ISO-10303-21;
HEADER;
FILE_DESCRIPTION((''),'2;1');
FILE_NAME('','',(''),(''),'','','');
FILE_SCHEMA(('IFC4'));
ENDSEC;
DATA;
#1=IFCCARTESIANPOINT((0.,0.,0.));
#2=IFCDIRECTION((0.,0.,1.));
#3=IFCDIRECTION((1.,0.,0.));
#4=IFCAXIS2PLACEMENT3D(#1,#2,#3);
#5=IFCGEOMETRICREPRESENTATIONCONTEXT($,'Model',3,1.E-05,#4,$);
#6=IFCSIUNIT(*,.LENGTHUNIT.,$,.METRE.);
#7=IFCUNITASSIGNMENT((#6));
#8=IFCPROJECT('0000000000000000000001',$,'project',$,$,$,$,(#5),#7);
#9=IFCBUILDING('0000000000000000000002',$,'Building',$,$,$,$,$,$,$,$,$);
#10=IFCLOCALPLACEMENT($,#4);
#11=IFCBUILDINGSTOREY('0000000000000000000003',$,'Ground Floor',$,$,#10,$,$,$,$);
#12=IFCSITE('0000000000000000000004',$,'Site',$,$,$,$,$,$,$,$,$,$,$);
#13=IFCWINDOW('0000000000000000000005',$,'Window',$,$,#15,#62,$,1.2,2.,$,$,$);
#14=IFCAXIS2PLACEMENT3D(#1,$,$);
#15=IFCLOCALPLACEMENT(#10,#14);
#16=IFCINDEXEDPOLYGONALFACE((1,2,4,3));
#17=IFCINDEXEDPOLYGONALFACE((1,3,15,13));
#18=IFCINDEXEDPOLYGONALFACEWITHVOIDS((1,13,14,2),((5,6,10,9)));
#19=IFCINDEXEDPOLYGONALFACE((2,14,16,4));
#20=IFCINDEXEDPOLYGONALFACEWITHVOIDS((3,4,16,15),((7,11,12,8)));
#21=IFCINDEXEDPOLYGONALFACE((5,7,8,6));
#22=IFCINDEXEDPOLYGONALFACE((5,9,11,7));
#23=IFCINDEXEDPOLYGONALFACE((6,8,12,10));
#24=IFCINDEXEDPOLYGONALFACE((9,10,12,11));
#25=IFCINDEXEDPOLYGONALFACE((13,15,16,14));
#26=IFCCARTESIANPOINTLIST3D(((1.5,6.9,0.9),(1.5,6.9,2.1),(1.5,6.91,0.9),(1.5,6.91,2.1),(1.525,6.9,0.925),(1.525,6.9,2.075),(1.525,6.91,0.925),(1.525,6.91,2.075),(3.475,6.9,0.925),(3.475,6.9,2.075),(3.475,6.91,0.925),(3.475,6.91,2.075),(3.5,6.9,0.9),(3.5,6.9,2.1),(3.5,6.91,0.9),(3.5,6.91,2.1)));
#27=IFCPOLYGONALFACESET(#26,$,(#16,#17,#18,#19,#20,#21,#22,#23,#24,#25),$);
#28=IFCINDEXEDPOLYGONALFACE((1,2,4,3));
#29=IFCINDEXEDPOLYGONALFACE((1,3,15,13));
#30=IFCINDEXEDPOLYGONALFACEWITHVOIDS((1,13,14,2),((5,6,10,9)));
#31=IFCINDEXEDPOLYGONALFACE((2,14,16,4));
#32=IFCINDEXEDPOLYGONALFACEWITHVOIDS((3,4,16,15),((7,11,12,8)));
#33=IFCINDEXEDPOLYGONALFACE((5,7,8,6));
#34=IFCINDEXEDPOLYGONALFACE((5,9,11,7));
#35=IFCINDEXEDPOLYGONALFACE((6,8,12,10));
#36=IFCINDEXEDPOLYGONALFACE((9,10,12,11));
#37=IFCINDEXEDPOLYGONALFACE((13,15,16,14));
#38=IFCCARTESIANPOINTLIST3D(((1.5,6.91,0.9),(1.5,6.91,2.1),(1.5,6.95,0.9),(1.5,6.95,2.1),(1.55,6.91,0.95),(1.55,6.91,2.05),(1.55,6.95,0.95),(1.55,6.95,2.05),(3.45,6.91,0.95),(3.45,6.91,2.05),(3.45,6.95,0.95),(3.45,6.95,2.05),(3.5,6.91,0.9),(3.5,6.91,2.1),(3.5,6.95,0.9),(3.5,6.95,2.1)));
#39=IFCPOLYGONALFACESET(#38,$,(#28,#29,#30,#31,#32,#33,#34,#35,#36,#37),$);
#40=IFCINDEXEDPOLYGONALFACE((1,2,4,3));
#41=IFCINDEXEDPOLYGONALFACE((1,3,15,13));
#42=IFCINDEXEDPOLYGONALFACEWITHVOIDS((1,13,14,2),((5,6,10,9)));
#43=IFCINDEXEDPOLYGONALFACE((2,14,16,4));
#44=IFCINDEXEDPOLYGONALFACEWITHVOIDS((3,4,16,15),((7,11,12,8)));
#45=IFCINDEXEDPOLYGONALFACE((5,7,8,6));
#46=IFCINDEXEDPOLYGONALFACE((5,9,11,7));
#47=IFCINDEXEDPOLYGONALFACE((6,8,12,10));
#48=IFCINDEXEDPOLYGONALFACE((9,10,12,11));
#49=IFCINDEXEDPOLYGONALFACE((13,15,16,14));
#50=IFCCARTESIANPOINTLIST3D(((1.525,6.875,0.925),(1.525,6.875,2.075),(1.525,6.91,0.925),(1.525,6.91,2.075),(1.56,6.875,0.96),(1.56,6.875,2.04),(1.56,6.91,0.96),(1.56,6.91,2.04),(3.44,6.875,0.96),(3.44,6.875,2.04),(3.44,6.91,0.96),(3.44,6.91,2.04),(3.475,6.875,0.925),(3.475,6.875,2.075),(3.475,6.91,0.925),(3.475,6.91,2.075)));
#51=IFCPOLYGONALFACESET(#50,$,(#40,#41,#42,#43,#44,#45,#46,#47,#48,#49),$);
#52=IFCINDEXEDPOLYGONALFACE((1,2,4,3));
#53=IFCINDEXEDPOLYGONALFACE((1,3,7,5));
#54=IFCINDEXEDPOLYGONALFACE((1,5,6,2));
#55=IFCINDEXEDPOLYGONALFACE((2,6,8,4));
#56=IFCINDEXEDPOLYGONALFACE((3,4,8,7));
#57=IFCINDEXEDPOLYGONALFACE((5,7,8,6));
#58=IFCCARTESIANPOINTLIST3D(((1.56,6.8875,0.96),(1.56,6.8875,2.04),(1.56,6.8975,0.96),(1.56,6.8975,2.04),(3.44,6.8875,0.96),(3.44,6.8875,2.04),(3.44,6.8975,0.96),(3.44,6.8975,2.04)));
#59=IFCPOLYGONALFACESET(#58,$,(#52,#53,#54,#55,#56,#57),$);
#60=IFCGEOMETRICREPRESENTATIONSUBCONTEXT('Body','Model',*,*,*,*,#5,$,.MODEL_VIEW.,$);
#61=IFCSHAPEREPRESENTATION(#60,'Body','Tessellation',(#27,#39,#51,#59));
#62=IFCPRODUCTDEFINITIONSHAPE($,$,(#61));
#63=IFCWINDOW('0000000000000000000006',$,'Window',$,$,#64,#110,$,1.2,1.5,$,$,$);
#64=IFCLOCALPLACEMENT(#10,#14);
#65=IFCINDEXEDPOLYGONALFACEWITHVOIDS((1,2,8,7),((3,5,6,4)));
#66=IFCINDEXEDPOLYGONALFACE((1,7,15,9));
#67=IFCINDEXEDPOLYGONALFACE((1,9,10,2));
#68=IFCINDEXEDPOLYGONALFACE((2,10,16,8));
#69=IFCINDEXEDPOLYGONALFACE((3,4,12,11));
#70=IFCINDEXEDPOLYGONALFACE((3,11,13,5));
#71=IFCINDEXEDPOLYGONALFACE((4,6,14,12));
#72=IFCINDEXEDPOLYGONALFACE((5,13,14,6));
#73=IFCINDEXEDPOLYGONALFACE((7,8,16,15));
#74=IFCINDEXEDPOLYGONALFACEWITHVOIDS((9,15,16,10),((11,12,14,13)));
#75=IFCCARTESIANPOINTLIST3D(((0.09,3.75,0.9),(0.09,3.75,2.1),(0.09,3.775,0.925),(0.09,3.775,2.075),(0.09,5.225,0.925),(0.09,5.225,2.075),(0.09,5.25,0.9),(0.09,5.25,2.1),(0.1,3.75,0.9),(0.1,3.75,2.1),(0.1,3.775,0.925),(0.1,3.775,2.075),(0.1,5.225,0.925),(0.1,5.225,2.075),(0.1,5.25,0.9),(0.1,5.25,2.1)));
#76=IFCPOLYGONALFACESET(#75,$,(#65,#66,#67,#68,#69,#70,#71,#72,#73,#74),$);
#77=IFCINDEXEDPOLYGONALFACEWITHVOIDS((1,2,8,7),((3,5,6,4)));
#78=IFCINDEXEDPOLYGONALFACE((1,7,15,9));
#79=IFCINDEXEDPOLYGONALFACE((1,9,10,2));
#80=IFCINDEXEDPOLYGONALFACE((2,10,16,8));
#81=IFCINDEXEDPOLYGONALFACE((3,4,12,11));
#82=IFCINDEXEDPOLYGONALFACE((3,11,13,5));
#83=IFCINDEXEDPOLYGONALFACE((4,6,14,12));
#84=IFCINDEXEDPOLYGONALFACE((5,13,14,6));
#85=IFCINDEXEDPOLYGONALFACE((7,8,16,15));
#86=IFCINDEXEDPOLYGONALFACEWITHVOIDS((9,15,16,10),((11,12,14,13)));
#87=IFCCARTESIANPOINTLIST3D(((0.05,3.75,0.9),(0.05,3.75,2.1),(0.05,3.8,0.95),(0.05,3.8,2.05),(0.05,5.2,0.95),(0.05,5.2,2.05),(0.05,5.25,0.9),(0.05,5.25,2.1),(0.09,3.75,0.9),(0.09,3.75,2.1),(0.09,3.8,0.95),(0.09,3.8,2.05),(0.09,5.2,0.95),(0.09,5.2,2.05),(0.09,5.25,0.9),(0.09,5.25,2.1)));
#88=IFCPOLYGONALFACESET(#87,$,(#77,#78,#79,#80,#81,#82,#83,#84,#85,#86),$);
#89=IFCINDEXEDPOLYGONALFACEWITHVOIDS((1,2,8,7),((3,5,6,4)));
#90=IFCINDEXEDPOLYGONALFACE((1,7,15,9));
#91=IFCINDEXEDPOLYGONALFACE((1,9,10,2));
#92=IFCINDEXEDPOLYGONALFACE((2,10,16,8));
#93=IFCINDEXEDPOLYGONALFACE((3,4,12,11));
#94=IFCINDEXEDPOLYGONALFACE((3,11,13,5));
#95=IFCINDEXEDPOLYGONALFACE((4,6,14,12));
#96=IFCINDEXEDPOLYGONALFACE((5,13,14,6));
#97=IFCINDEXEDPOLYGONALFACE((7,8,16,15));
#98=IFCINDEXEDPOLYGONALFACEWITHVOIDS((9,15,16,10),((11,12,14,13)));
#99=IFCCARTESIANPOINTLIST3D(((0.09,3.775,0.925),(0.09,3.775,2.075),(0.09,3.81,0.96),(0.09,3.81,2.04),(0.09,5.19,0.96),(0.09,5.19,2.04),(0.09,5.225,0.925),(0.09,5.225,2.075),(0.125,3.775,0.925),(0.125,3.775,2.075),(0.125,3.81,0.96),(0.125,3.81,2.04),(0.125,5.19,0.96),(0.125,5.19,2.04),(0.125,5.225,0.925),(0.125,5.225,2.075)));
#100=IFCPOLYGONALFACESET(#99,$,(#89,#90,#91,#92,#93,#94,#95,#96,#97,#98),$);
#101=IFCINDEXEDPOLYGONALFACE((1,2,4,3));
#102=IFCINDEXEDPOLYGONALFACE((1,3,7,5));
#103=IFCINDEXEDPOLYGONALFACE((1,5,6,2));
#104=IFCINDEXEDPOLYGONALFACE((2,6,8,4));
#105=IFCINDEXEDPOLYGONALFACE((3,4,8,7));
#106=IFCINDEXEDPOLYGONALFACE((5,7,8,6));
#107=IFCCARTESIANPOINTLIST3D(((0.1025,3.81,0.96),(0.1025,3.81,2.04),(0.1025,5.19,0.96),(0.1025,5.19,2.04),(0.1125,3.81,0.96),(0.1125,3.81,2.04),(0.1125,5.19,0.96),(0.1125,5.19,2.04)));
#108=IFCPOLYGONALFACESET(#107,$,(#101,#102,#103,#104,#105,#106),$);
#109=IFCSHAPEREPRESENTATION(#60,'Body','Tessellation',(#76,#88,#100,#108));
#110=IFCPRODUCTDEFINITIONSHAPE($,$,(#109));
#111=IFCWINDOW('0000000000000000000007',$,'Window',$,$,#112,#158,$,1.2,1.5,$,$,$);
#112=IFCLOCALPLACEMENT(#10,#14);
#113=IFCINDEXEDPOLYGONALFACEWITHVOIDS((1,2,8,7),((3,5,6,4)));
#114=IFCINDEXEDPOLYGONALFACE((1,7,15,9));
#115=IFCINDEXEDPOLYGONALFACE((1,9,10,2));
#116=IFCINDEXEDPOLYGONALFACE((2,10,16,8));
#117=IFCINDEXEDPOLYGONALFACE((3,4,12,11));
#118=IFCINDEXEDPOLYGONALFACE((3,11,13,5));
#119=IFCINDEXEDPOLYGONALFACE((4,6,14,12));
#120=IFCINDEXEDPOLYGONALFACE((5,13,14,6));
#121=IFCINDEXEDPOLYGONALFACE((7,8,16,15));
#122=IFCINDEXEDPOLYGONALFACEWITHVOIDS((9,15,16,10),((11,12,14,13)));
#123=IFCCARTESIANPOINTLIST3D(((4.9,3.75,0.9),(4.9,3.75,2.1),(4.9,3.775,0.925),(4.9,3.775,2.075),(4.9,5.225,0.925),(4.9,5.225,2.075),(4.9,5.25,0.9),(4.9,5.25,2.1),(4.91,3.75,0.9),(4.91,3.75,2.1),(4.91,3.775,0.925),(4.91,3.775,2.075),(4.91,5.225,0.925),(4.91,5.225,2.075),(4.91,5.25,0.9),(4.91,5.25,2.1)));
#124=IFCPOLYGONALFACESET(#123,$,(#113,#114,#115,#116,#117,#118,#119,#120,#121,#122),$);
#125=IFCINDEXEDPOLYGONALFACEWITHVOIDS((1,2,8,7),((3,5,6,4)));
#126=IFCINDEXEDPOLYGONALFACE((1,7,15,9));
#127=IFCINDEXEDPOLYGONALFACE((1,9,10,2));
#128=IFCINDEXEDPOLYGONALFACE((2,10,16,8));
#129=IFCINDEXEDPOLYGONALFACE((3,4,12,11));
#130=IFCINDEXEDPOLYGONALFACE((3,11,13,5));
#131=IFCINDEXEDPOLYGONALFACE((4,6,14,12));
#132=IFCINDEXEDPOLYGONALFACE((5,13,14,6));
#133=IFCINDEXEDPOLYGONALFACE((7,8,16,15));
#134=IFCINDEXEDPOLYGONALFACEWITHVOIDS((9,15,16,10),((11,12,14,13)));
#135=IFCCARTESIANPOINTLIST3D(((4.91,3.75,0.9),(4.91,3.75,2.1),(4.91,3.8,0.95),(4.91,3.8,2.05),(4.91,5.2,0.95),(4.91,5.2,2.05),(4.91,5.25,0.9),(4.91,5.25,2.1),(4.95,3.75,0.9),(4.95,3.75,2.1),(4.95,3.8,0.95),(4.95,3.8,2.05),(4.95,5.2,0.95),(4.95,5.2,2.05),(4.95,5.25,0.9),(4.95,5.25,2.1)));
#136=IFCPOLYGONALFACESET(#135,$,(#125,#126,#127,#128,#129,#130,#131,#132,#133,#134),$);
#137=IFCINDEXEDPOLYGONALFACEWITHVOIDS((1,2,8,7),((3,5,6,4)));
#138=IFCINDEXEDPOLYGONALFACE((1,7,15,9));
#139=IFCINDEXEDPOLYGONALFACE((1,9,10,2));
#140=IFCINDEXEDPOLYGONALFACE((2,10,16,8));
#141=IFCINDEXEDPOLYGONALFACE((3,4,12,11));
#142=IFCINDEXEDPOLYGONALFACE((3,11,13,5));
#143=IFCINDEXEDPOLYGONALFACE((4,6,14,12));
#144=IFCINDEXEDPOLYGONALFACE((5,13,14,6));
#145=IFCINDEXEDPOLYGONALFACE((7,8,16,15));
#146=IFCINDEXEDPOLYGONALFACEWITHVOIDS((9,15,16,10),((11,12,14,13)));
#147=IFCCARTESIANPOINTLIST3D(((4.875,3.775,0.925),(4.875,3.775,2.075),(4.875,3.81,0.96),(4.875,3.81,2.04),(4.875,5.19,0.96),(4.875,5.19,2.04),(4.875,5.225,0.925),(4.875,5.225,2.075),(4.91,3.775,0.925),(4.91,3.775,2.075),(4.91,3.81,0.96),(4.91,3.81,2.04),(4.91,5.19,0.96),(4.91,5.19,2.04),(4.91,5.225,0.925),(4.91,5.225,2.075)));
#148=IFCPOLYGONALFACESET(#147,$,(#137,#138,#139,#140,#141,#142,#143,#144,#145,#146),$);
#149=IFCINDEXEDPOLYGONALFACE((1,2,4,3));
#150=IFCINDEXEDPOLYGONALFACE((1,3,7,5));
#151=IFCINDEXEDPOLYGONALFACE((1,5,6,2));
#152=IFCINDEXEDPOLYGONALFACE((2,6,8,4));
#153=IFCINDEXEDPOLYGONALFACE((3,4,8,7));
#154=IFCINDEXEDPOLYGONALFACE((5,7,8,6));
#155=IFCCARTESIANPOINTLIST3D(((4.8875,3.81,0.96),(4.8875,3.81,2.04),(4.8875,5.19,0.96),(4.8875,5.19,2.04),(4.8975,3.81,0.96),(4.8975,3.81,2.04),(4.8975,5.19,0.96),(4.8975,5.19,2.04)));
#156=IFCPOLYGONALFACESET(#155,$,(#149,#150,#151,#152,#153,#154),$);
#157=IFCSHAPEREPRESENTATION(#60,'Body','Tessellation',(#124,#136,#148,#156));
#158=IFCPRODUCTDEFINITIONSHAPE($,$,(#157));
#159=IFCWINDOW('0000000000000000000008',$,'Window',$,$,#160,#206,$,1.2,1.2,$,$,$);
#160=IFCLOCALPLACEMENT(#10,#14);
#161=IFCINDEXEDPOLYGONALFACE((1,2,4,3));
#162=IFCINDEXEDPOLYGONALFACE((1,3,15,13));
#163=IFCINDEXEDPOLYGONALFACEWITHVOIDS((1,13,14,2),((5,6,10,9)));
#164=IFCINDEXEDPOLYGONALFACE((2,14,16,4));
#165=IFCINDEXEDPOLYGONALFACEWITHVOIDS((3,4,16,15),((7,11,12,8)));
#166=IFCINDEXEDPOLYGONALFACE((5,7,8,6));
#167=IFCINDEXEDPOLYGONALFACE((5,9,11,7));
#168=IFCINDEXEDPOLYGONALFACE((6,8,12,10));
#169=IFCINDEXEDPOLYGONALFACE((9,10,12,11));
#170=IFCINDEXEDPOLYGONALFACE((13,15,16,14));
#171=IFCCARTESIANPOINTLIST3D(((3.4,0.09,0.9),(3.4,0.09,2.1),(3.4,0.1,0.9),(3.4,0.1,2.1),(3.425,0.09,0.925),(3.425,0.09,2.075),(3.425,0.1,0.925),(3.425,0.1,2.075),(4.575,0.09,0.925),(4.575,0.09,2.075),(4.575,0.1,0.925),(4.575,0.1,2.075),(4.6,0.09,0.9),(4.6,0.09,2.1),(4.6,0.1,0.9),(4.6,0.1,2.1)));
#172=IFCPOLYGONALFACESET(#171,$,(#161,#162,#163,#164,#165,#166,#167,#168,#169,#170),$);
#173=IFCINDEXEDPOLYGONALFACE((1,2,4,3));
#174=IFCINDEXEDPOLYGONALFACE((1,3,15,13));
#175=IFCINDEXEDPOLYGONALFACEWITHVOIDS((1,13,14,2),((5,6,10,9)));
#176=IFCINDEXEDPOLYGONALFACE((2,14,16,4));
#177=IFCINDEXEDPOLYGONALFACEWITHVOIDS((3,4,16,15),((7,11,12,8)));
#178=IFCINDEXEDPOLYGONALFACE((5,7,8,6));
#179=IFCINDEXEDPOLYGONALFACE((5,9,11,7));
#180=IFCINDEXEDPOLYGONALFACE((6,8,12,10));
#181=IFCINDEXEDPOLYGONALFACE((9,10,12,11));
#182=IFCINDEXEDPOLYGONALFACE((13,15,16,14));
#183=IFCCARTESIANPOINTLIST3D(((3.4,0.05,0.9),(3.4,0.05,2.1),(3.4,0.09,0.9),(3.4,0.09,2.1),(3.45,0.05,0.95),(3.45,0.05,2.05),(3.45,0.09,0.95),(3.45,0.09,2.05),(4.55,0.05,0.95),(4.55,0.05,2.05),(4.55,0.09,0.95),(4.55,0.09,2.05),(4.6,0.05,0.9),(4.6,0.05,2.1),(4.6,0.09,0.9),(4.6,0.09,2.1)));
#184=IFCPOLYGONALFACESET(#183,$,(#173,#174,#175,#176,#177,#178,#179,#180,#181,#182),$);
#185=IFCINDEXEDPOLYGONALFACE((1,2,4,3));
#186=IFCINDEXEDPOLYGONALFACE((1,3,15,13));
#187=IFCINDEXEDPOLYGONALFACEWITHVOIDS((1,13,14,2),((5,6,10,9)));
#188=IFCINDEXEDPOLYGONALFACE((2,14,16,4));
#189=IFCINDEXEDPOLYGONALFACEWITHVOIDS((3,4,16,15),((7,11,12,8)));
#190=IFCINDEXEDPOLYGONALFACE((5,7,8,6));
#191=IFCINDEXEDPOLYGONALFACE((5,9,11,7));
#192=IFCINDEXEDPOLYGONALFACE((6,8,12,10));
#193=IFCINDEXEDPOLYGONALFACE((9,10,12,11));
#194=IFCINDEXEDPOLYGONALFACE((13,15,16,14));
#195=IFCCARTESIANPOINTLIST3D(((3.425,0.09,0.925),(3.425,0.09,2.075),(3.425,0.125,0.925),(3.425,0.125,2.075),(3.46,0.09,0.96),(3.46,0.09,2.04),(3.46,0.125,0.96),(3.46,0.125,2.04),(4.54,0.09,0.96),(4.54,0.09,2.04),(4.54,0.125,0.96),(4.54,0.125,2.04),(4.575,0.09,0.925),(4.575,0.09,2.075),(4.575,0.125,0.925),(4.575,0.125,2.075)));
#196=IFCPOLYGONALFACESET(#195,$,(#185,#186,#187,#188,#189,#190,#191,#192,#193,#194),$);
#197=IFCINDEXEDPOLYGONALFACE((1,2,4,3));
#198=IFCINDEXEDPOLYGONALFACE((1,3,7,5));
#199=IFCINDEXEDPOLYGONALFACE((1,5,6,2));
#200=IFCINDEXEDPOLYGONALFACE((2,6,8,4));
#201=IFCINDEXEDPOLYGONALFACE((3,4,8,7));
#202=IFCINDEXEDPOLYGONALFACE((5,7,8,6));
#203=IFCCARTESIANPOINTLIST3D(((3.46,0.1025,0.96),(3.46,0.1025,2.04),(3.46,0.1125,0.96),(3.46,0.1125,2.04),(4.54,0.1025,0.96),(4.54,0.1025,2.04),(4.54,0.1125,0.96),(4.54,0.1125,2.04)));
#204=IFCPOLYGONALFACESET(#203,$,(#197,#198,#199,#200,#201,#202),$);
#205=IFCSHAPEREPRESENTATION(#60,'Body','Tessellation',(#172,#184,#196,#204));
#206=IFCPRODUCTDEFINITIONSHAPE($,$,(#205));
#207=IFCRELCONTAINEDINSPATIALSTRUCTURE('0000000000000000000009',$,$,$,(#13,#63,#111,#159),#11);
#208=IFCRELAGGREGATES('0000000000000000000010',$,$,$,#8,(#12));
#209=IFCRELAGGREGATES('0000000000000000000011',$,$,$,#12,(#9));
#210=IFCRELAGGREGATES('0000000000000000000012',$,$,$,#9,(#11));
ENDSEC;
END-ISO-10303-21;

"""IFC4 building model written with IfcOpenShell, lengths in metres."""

from ifc_helpers import new_model, si_unit, frame, origin_with_axes, place, context, subcontext, project, spatial, line, indexed_curve, outline, extrude, element, save


model = new_model("IFC4")

# Units and contexts
model_context = context("Model", 3, precision=1e-05, world=origin_with_axes())
body_context = subcontext(model_context, "Body", "Model", "MODEL_VIEW")
ifc_project = project(units=[si_unit("LENGTHUNIT", "METRE")], contexts=[model_context])

# Site, building, storey
site = spatial("IfcSite", under=ifc_project, Name="Site")
building = spatial("IfcBuilding", under=site, Name="Building")
storey_placement = place(None, origin_with_axes())
storey = spatial("IfcBuildingStorey", under=building, at=storey_placement, Name="Ground Floor")

# Windows
window_1_placement = place(storey_placement, frame((3.5, 7.0, 0.9), z_axis=(0.0, 0.0, 1.0), x_axis=(-1.0, 0.0, 0.0)))
element("IfcWindow", 1, at=window_1_placement, inside=storey, Name="Window", OverallHeight=1.2, OverallWidth=2.0, context=body_context, shape_type="SweptSolid", body=[
    extrude(outline(indexed_curve([(0.0, 0.0), (2.0, 0.0), (2.0, 1.2), (0.0, 1.2)], segments=[line(1, 2, 3, 4, 1)]), holes=[indexed_curve([(0.025, 0.025), (1.975, 0.025), (1.975, 1.175), (0.025, 1.175)], segments=[line(1, 2, 3, 4, 1)])]), frame((0.0, 0.09, 0.0), z_axis=(0.0, -1.0, 0.0), x_axis=(1.0, 0.0, 0.0)), (0.0, 0.0, -1.0), 0.01),
    extrude(outline(indexed_curve([(0.0, 0.0), (2.0, 0.0), (2.0, 1.2), (0.0, 1.2)], segments=[line(1, 2, 3, 4, 1)]), holes=[indexed_curve([(0.05, 0.05), (1.95, 0.05), (1.95, 1.15), (0.05, 1.15)], segments=[line(1, 2, 3, 4, 1)])]), frame((0.0, 0.05, 0.0), z_axis=(0.0, -1.0, 0.0), x_axis=(1.0, 0.0, 0.0)), (0.0, 0.0, -1.0), 0.04),
    extrude(outline(indexed_curve([(0.0, 0.0), (1.95, 0.0), (1.95, 1.15), (0.0, 1.15)], segments=[line(1, 2, 3, 4, 1)]), holes=[indexed_curve([(0.035, 0.035), (1.915, 0.035), (1.915, 1.115), (0.035, 1.115)], segments=[line(1, 2, 3, 4, 1)])]), frame((0.025, 0.09, 0.025), z_axis=(0.0, -1.0, 0.0), x_axis=(1.0, 0.0, 0.0)), (0.0, 0.0, -1.0), 0.035),
    extrude(outline(indexed_curve([(0.035, 0.035), (1.915, 0.035), (1.915, 1.115), (0.035, 1.115)], segments=[line(1, 2, 3, 4, 1)])), frame((0.025, 0.1025, 0.025), z_axis=(0.0, -1.0, 0.0), x_axis=(1.0, 0.0, 0.0)), (0.0, 0.0, -1.0), 0.01),
])
for number, where, z_axis, x_axis, name in (
    (2, (0.0, 5.25, 0.9), (0.0, 0.0, 1.0), (0.0, -1.0, 0.0), "Window"),
    (3, (5.0, 3.75, 0.9), (0.0, 0.0, 1.0), (0.0, 1.0, 0.0), "Window"),
):
    element("IfcWindow", number, at=place(storey_placement, frame(where, z_axis=z_axis, x_axis=x_axis)), inside=storey, Name=name, OverallHeight=1.2, OverallWidth=1.5, context=body_context, shape_type="SweptSolid", body=[
        extrude(outline(indexed_curve([(0.0, 0.0), (1.5, 0.0), (1.5, 1.2), (0.0, 1.2)], segments=[line(1, 2, 3, 4, 1)]), holes=[indexed_curve([(0.025, 0.025), (1.475, 0.025), (1.475, 1.175), (0.025, 1.175)], segments=[line(1, 2, 3, 4, 1)])]), frame((0.0, 0.09, 0.0), z_axis=(0.0, -1.0, 0.0), x_axis=(1.0, 0.0, 0.0)), (0.0, 0.0, -1.0), 0.01),
        extrude(outline(indexed_curve([(0.0, 0.0), (1.5, 0.0), (1.5, 1.2), (0.0, 1.2)], segments=[line(1, 2, 3, 4, 1)]), holes=[indexed_curve([(0.05, 0.05), (1.45, 0.05), (1.45, 1.15), (0.05, 1.15)], segments=[line(1, 2, 3, 4, 1)])]), frame((0.0, 0.05, 0.0), z_axis=(0.0, -1.0, 0.0), x_axis=(1.0, 0.0, 0.0)), (0.0, 0.0, -1.0), 0.04),
        extrude(outline(indexed_curve([(0.0, 0.0), (1.45, 0.0), (1.45, 1.15), (0.0, 1.15)], segments=[line(1, 2, 3, 4, 1)]), holes=[indexed_curve([(0.035, 0.035), (1.415, 0.035), (1.415, 1.115), (0.035, 1.115)], segments=[line(1, 2, 3, 4, 1)])]), frame((0.025, 0.09, 0.025), z_axis=(0.0, -1.0, 0.0), x_axis=(1.0, 0.0, 0.0)), (0.0, 0.0, -1.0), 0.035),
        extrude(outline(indexed_curve([(0.035, 0.035), (1.415, 0.035), (1.415, 1.115), (0.035, 1.115)], segments=[line(1, 2, 3, 4, 1)])), frame((0.025, 0.1025, 0.025), z_axis=(0.0, -1.0, 0.0), x_axis=(1.0, 0.0, 0.0)), (0.0, 0.0, -1.0), 0.01),
    ])
window_2_placement = place(storey_placement, frame((3.4, 0.0, 0.9), z_axis=(0.0, 0.0, 1.0), x_axis=(1.0, 0.0, 0.0)))
element("IfcWindow", 4, at=window_2_placement, inside=storey, Name="Window", OverallHeight=1.2, OverallWidth=1.2, context=body_context, shape_type="SweptSolid", body=[
    extrude(outline(indexed_curve([(0.0, 0.0), (1.2, 0.0), (1.2, 1.2), (0.0, 1.2)], segments=[line(1, 2, 3, 4, 1)]), holes=[indexed_curve([(0.025, 0.025), (1.175, 0.025), (1.175, 1.175), (0.025, 1.175)], segments=[line(1, 2, 3, 4, 1)])]), frame((0.0, 0.09, 0.0), z_axis=(0.0, -1.0, 0.0), x_axis=(1.0, 0.0, 0.0)), (0.0, 0.0, -1.0), 0.01),
    extrude(outline(indexed_curve([(0.0, 0.0), (1.2, 0.0), (1.2, 1.2), (0.0, 1.2)], segments=[line(1, 2, 3, 4, 1)]), holes=[indexed_curve([(0.05, 0.05), (1.15, 0.05), (1.15, 1.15), (0.05, 1.15)], segments=[line(1, 2, 3, 4, 1)])]), frame((0.0, 0.05, 0.0), z_axis=(0.0, -1.0, 0.0), x_axis=(1.0, 0.0, 0.0)), (0.0, 0.0, -1.0), 0.04),
    extrude(outline(indexed_curve([(0.0, 0.0), (1.15, 0.0), (1.15, 1.15), (0.0, 1.15)], segments=[line(1, 2, 3, 4, 1)]), holes=[indexed_curve([(0.035, 0.035), (1.115, 0.035), (1.115, 1.115), (0.035, 1.115)], segments=[line(1, 2, 3, 4, 1)])]), frame((0.025, 0.09, 0.025), z_axis=(0.0, -1.0, 0.0), x_axis=(1.0, 0.0, 0.0)), (0.0, 0.0, -1.0), 0.035),
    extrude(outline(indexed_curve([(0.035, 0.035), (1.115, 0.035), (1.115, 1.115), (0.035, 1.115)], segments=[line(1, 2, 3, 4, 1)])), frame((0.025, 0.1025, 0.025), z_axis=(0.0, -1.0, 0.0), x_axis=(1.0, 0.0, 0.0)), (0.0, 0.0, -1.0), 0.01),
])

save(model, "model.ifc")
